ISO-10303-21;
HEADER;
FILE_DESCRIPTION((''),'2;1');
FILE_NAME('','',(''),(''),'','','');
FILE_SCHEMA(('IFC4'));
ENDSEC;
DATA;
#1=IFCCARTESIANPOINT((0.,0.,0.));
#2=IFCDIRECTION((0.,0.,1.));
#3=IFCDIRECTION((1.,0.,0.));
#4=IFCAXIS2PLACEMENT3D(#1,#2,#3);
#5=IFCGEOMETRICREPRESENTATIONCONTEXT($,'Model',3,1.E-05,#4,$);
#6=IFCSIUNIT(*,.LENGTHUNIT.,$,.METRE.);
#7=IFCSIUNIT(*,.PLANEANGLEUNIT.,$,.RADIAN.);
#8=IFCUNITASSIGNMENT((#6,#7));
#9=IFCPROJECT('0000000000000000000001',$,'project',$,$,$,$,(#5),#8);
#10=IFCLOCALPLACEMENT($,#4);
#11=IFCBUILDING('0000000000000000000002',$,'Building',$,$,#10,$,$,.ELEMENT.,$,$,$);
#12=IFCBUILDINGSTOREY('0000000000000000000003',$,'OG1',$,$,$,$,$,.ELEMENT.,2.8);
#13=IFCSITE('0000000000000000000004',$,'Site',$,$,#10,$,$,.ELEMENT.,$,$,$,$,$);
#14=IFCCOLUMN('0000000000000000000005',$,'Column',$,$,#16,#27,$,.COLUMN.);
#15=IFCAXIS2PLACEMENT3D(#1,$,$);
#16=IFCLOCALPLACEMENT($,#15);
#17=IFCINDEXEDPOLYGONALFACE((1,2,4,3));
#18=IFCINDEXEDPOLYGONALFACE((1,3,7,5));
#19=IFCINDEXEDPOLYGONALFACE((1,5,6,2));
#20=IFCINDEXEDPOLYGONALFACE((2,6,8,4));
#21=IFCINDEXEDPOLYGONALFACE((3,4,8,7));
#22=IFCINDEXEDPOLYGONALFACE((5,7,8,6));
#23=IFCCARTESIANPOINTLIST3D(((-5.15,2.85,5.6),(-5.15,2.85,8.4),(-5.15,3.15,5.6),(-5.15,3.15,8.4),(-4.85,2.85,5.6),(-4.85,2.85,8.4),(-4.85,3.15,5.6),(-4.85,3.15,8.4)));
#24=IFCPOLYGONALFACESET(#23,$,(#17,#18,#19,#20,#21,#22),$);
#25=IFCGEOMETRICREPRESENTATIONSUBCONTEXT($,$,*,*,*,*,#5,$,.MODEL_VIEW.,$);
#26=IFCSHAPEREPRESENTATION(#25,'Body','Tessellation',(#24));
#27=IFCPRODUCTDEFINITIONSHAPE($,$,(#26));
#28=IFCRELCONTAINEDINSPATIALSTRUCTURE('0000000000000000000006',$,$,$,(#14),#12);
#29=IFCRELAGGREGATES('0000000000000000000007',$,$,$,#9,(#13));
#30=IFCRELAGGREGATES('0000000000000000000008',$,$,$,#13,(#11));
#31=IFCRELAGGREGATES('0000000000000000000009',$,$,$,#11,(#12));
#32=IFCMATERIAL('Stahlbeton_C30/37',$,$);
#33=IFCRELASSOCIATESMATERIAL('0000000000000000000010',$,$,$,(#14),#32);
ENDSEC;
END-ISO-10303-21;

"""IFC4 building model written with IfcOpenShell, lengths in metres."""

from ifc_helpers import new_model, si_unit, frame, origin, origin_with_axes, origin_2d, place, context, subcontext, project, spatial, rectangle, extrude, material, element, save


model = new_model("IFC4")

# Units and contexts
model_context = context("Model", 3, precision=1e-05, world=origin_with_axes())
sub_context = subcontext(model_context, None, None, "MODEL_VIEW")
ifc_project = project(units=[si_unit("LENGTHUNIT", "METRE"), si_unit("PLANEANGLEUNIT", "RADIAN")], contexts=[model_context])

# Site, building, storey
placement_1 = place(None, origin_with_axes())
site = spatial("IfcSite", under=ifc_project, at=placement_1, Name="Site", CompositionType="ELEMENT")
building = spatial("IfcBuilding", under=site, at=placement_1, Name="Building", CompositionType="ELEMENT")
storey = spatial("IfcBuildingStorey", under=building, Name="OG1", CompositionType="ELEMENT", Elevation=2.8)

# Column
ifc_material = material(Name="Stahlbeton_C30/37")
placement_2 = place(None, origin_with_axes())
placement_3 = place(placement_2, frame((0.0, 0.0, 2.8)))
column_placement = place(placement_3, frame((-5.0, 3.0, 2.8)))
element("IfcColumn", 1, at=column_placement, inside=storey, material=ifc_material, Name="Column", PredefinedType="COLUMN", context=sub_context, shape_type="SweptSolid", body=[
    extrude(rectangle(XDim=0.3, YDim=0.3, at=origin_2d()), origin(), (0.0, 0.0, 1.0), 2.8),
])

save(model, "model.ifc")
